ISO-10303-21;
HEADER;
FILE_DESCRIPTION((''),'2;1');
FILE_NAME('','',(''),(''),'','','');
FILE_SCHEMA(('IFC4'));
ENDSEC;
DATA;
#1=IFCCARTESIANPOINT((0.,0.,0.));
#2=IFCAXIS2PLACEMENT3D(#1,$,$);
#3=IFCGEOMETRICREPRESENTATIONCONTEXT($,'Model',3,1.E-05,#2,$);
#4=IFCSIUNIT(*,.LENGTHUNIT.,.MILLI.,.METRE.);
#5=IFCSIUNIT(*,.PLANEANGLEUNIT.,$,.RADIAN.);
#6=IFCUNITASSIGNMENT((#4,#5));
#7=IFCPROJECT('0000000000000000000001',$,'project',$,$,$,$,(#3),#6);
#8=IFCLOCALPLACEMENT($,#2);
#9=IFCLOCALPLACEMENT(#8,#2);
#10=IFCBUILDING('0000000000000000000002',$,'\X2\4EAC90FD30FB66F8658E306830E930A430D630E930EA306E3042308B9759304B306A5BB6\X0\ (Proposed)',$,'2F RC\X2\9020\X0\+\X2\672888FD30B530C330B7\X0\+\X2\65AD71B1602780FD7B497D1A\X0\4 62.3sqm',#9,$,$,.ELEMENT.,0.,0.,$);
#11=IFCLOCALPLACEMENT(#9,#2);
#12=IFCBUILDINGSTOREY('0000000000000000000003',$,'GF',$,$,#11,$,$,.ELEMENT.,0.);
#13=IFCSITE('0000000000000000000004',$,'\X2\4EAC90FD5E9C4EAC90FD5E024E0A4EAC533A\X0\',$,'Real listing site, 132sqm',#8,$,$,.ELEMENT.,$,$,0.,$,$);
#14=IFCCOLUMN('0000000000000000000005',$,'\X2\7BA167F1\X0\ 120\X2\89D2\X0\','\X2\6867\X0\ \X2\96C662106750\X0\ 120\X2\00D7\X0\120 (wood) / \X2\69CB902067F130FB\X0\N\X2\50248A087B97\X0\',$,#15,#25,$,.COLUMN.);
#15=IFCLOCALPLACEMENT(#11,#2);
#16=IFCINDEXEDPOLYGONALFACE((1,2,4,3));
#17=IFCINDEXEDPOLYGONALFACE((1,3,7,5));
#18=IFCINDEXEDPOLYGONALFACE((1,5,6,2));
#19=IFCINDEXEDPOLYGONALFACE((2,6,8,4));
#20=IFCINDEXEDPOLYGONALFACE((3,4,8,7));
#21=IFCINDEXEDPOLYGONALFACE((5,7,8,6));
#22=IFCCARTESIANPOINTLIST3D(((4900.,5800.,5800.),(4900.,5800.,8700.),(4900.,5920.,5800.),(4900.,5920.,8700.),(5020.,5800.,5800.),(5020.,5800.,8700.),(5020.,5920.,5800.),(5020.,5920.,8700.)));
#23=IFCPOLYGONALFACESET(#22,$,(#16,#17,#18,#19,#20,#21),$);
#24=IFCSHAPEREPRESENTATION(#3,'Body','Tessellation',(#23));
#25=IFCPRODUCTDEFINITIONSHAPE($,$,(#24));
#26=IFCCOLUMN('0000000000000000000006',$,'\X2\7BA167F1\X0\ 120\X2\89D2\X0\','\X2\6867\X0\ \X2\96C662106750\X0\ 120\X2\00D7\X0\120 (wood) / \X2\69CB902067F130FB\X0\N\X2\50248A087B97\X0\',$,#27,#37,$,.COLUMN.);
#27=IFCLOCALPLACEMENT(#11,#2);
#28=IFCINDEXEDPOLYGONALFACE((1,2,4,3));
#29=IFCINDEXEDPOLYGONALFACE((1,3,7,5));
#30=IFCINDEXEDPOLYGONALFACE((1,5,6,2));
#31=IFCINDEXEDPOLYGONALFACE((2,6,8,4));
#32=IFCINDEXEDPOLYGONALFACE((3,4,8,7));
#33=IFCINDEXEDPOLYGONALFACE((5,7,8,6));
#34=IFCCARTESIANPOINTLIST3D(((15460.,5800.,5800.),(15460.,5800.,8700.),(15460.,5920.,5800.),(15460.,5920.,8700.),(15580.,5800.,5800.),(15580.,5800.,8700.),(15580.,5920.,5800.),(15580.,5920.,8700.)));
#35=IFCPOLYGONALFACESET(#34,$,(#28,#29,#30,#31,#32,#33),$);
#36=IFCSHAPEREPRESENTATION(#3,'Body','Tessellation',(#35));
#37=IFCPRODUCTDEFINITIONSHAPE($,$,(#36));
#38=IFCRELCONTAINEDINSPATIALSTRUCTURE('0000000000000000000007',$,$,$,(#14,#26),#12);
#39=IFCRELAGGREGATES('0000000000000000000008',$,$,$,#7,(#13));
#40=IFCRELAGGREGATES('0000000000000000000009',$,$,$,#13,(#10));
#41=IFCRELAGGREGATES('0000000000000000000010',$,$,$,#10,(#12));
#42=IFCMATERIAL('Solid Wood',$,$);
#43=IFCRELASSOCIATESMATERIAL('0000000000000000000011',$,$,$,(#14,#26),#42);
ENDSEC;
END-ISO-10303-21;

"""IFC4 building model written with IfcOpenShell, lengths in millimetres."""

from ifc_helpers import new_model, si_unit, frame, frame_2d, origin, place, context, project, spatial, rectangle, extrude, material, element, save


model = new_model("IFC4")

# Units and contexts
model_context = context("Model", 3, precision=1e-05, world=origin())
ifc_project = project(units=[si_unit("LENGTHUNIT", "METRE", prefix="MILLI"), si_unit("PLANEANGLEUNIT", "RADIAN")], contexts=[model_context])

# Site, building, storey
site_placement = place(None, origin())
site = spatial("IfcSite", under=ifc_project, at=site_placement, Name="京都府京都市上京区", ObjectType="Real listing site, 132sqm", CompositionType="ELEMENT", RefElevation=0.0)
building_placement = place(site_placement, origin())
building = spatial("IfcBuilding", under=site, at=building_placement, Name="京都・書斎とライブラリのある静かな家 (Proposed)", ObjectType="2F RC造+木製サッシ+断熱性能等級4 62.3sqm", CompositionType="ELEMENT", ElevationOfRefHeight=0.0, ElevationOfTerrain=0.0)
storey_placement = place(building_placement, origin())
storey = spatial("IfcBuildingStorey", under=building, at=storey_placement, Name="GF", CompositionType="ELEMENT", Elevation=0.0)

# Columns
ifc_material_1 = material(Name="Solid Wood")
column_1_placement = place(storey_placement, frame((2450.0, 2900.0, 2900.0)))
element("IfcColumn", 1, at=column_1_placement, inside=storey, material=ifc_material_1, Name="管柱 120角", Description="桧 集成材 120×120 (wood) / 構造柱・N値計算", PredefinedType="COLUMN", context=model_context, shape_type="SweptSolid", body=[
    extrude(rectangle(XDim=120.0, YDim=120.0, at=frame_2d((60.0, 60.0))), frame((2450.0, 2900.0, 2900.0)), (0.0, 0.0, 1.0), 2900.0),
])
column_2_placement = place(storey_placement, frame((7730.0, 2900.0, 2900.0)))
element("IfcColumn", 2, at=column_2_placement, inside=storey, material=ifc_material_1, Name="管柱 120角", Description="桧 集成材 120×120 (wood) / 構造柱・N値計算", PredefinedType="COLUMN", context=model_context, shape_type="SweptSolid", body=[
    extrude(rectangle(XDim=120.0, YDim=120.0, at=frame_2d((60.0, 60.0))), frame((7730.0, 2900.0, 2900.0)), (0.0, 0.0, 1.0), 2900.0),
])

save(model, "model.ifc")
